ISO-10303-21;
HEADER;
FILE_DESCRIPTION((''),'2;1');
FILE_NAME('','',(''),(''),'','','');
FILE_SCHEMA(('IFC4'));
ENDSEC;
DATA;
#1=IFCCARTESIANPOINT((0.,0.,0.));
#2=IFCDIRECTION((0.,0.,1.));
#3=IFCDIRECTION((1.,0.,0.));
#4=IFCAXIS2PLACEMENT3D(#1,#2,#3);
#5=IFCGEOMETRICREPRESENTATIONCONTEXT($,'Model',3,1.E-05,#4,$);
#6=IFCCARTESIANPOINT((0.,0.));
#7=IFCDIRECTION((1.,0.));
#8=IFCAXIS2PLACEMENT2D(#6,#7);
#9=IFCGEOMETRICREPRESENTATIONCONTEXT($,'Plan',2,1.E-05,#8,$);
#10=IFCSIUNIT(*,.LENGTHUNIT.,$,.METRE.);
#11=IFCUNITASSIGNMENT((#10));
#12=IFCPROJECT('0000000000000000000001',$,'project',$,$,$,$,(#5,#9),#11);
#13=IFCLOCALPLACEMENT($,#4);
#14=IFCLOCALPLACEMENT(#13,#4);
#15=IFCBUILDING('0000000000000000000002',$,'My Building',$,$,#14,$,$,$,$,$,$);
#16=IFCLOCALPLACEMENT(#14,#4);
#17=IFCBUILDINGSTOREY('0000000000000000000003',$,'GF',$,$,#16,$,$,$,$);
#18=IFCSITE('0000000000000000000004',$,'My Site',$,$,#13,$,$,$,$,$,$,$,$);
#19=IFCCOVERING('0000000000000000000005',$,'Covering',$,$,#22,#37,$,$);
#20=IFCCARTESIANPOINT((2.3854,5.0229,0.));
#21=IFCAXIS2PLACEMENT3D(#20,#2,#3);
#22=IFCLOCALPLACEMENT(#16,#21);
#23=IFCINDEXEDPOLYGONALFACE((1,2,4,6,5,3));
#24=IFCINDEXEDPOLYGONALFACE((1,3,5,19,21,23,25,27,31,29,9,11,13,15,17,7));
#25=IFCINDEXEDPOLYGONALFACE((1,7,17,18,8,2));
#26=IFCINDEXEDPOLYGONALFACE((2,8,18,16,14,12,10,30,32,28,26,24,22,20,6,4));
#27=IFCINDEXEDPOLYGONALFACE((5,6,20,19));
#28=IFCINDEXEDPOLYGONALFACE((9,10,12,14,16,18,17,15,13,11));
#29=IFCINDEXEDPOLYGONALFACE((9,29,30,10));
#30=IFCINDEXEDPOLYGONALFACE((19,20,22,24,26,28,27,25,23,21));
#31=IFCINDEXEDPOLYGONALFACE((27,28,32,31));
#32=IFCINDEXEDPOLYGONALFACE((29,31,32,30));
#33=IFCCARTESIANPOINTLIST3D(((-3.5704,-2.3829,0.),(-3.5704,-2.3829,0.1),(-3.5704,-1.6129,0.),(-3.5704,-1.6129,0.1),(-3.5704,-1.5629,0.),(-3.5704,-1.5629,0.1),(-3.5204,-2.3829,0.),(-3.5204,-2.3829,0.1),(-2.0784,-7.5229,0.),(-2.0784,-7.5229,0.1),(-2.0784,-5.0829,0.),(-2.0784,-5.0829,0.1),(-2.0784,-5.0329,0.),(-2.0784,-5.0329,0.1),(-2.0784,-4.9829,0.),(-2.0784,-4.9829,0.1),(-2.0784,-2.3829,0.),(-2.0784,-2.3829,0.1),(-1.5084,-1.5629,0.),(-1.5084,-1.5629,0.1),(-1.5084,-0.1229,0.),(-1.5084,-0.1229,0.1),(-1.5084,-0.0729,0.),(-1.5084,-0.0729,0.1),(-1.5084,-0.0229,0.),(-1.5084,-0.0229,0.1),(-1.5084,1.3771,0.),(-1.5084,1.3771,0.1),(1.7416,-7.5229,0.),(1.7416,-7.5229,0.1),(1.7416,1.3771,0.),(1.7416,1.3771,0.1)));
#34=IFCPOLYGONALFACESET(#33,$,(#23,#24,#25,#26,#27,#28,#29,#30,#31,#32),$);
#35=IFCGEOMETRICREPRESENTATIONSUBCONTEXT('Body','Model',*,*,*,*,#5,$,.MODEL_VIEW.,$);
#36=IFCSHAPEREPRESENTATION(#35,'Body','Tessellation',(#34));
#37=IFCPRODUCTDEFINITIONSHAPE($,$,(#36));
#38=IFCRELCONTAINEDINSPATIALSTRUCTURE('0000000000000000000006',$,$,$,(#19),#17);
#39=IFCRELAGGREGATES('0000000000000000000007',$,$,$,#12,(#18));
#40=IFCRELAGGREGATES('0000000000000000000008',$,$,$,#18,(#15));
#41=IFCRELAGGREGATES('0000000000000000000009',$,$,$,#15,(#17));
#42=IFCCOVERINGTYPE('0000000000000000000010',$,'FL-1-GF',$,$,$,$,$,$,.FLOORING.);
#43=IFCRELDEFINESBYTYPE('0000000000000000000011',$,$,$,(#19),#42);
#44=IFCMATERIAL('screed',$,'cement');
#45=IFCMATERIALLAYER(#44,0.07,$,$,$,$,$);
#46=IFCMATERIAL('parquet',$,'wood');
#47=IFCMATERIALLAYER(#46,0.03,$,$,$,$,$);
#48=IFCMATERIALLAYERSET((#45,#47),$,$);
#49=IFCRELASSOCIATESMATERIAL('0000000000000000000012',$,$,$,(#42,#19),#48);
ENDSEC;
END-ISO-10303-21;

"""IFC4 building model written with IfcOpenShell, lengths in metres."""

from ifc_helpers import new_model, si_unit, frame, origin_with_axes, origin_2d_with_axis, place, context, subcontext, project, spatial, line, indexed_curve, outline, extrude, material, layer, layer_set, layer_usage, type_object, element, save


model = new_model("IFC4")

# Units and contexts
model_context = context("Model", 3, precision=1e-05, world=origin_with_axes())
plan_context = context("Plan", 2, precision=1e-05, world=origin_2d_with_axis())
body_context_1 = subcontext(model_context, "Body", "Model", "MODEL_VIEW")
ifc_project = project(units=[si_unit("LENGTHUNIT", "METRE")], contexts=[model_context, plan_context])

# Site, building, storey
site_placement = place(None, origin_with_axes())
site = spatial("IfcSite", under=ifc_project, at=site_placement, Name="My Site")
building_placement = place(site_placement, origin_with_axes())
building = spatial("IfcBuilding", under=site, at=building_placement, Name="My Building")
storey_placement = place(building_placement, origin_with_axes())
storey = spatial("IfcBuildingStorey", under=building, at=storey_placement, Name="GF")

# Covering
ifc_material_1 = material(Name="screed", Category="cement")
ifc_layer_1 = layer(ifc_material_1, 0.07)
ifc_material_2 = material(Name="parquet", Category="wood")
ifc_layer_2 = layer(ifc_material_2, 0.03)
ifc_layer_set_1 = layer_set([ifc_layer_1, ifc_layer_2])
ifc_layer_usage_1 = layer_usage(ifc_layer_set_1, "AXIS3", "POSITIVE", 0.0)
covering_type = type_object("IfcCoveringType", Name="FL-1-GF", PredefinedType="FLOORING", material=ifc_layer_set_1)
covering_placement = place(storey_placement, frame((2.3854, 5.0229, 0.0), z_axis=(0.0, 0.0, 1.0), x_axis=(1.0, 0.0, 0.0)))
element("IfcCovering", 1, at=covering_placement, inside=storey, type_object=covering_type, material=ifc_layer_usage_1, Name="Covering", context=body_context_1, shape_type="SweptSolid", body=[
    extrude(outline(indexed_curve([(-1.5084, 1.3771), (1.7416, 1.3771), (1.7416, -7.5229), (-2.0784, -7.5229), (-2.0784, -7.5229), (-2.0784, -5.0829), (-2.0784, -5.0329), (-2.0784, -5.0329), (-2.0784, -4.9829), (-2.0784, -2.3829), (-3.5204, -2.3829), (-3.5704, -2.3829), (-3.5704, -1.6129), (-3.5704, -1.5629), (-1.5084, -1.5629), (-1.5084, -0.1229), (-1.5084, -0.0729), (-1.5084, -0.0229)], segments=[line(1, 2, 3, 4, 5, 6, 7, 8, 9, 10, 11, 12, 13, 14, 15, 16, 17, 18, 1)])), origin_with_axes(), (0.0, 0.0, 1.0), 0.1),
])

save(model, "model.ifc")
